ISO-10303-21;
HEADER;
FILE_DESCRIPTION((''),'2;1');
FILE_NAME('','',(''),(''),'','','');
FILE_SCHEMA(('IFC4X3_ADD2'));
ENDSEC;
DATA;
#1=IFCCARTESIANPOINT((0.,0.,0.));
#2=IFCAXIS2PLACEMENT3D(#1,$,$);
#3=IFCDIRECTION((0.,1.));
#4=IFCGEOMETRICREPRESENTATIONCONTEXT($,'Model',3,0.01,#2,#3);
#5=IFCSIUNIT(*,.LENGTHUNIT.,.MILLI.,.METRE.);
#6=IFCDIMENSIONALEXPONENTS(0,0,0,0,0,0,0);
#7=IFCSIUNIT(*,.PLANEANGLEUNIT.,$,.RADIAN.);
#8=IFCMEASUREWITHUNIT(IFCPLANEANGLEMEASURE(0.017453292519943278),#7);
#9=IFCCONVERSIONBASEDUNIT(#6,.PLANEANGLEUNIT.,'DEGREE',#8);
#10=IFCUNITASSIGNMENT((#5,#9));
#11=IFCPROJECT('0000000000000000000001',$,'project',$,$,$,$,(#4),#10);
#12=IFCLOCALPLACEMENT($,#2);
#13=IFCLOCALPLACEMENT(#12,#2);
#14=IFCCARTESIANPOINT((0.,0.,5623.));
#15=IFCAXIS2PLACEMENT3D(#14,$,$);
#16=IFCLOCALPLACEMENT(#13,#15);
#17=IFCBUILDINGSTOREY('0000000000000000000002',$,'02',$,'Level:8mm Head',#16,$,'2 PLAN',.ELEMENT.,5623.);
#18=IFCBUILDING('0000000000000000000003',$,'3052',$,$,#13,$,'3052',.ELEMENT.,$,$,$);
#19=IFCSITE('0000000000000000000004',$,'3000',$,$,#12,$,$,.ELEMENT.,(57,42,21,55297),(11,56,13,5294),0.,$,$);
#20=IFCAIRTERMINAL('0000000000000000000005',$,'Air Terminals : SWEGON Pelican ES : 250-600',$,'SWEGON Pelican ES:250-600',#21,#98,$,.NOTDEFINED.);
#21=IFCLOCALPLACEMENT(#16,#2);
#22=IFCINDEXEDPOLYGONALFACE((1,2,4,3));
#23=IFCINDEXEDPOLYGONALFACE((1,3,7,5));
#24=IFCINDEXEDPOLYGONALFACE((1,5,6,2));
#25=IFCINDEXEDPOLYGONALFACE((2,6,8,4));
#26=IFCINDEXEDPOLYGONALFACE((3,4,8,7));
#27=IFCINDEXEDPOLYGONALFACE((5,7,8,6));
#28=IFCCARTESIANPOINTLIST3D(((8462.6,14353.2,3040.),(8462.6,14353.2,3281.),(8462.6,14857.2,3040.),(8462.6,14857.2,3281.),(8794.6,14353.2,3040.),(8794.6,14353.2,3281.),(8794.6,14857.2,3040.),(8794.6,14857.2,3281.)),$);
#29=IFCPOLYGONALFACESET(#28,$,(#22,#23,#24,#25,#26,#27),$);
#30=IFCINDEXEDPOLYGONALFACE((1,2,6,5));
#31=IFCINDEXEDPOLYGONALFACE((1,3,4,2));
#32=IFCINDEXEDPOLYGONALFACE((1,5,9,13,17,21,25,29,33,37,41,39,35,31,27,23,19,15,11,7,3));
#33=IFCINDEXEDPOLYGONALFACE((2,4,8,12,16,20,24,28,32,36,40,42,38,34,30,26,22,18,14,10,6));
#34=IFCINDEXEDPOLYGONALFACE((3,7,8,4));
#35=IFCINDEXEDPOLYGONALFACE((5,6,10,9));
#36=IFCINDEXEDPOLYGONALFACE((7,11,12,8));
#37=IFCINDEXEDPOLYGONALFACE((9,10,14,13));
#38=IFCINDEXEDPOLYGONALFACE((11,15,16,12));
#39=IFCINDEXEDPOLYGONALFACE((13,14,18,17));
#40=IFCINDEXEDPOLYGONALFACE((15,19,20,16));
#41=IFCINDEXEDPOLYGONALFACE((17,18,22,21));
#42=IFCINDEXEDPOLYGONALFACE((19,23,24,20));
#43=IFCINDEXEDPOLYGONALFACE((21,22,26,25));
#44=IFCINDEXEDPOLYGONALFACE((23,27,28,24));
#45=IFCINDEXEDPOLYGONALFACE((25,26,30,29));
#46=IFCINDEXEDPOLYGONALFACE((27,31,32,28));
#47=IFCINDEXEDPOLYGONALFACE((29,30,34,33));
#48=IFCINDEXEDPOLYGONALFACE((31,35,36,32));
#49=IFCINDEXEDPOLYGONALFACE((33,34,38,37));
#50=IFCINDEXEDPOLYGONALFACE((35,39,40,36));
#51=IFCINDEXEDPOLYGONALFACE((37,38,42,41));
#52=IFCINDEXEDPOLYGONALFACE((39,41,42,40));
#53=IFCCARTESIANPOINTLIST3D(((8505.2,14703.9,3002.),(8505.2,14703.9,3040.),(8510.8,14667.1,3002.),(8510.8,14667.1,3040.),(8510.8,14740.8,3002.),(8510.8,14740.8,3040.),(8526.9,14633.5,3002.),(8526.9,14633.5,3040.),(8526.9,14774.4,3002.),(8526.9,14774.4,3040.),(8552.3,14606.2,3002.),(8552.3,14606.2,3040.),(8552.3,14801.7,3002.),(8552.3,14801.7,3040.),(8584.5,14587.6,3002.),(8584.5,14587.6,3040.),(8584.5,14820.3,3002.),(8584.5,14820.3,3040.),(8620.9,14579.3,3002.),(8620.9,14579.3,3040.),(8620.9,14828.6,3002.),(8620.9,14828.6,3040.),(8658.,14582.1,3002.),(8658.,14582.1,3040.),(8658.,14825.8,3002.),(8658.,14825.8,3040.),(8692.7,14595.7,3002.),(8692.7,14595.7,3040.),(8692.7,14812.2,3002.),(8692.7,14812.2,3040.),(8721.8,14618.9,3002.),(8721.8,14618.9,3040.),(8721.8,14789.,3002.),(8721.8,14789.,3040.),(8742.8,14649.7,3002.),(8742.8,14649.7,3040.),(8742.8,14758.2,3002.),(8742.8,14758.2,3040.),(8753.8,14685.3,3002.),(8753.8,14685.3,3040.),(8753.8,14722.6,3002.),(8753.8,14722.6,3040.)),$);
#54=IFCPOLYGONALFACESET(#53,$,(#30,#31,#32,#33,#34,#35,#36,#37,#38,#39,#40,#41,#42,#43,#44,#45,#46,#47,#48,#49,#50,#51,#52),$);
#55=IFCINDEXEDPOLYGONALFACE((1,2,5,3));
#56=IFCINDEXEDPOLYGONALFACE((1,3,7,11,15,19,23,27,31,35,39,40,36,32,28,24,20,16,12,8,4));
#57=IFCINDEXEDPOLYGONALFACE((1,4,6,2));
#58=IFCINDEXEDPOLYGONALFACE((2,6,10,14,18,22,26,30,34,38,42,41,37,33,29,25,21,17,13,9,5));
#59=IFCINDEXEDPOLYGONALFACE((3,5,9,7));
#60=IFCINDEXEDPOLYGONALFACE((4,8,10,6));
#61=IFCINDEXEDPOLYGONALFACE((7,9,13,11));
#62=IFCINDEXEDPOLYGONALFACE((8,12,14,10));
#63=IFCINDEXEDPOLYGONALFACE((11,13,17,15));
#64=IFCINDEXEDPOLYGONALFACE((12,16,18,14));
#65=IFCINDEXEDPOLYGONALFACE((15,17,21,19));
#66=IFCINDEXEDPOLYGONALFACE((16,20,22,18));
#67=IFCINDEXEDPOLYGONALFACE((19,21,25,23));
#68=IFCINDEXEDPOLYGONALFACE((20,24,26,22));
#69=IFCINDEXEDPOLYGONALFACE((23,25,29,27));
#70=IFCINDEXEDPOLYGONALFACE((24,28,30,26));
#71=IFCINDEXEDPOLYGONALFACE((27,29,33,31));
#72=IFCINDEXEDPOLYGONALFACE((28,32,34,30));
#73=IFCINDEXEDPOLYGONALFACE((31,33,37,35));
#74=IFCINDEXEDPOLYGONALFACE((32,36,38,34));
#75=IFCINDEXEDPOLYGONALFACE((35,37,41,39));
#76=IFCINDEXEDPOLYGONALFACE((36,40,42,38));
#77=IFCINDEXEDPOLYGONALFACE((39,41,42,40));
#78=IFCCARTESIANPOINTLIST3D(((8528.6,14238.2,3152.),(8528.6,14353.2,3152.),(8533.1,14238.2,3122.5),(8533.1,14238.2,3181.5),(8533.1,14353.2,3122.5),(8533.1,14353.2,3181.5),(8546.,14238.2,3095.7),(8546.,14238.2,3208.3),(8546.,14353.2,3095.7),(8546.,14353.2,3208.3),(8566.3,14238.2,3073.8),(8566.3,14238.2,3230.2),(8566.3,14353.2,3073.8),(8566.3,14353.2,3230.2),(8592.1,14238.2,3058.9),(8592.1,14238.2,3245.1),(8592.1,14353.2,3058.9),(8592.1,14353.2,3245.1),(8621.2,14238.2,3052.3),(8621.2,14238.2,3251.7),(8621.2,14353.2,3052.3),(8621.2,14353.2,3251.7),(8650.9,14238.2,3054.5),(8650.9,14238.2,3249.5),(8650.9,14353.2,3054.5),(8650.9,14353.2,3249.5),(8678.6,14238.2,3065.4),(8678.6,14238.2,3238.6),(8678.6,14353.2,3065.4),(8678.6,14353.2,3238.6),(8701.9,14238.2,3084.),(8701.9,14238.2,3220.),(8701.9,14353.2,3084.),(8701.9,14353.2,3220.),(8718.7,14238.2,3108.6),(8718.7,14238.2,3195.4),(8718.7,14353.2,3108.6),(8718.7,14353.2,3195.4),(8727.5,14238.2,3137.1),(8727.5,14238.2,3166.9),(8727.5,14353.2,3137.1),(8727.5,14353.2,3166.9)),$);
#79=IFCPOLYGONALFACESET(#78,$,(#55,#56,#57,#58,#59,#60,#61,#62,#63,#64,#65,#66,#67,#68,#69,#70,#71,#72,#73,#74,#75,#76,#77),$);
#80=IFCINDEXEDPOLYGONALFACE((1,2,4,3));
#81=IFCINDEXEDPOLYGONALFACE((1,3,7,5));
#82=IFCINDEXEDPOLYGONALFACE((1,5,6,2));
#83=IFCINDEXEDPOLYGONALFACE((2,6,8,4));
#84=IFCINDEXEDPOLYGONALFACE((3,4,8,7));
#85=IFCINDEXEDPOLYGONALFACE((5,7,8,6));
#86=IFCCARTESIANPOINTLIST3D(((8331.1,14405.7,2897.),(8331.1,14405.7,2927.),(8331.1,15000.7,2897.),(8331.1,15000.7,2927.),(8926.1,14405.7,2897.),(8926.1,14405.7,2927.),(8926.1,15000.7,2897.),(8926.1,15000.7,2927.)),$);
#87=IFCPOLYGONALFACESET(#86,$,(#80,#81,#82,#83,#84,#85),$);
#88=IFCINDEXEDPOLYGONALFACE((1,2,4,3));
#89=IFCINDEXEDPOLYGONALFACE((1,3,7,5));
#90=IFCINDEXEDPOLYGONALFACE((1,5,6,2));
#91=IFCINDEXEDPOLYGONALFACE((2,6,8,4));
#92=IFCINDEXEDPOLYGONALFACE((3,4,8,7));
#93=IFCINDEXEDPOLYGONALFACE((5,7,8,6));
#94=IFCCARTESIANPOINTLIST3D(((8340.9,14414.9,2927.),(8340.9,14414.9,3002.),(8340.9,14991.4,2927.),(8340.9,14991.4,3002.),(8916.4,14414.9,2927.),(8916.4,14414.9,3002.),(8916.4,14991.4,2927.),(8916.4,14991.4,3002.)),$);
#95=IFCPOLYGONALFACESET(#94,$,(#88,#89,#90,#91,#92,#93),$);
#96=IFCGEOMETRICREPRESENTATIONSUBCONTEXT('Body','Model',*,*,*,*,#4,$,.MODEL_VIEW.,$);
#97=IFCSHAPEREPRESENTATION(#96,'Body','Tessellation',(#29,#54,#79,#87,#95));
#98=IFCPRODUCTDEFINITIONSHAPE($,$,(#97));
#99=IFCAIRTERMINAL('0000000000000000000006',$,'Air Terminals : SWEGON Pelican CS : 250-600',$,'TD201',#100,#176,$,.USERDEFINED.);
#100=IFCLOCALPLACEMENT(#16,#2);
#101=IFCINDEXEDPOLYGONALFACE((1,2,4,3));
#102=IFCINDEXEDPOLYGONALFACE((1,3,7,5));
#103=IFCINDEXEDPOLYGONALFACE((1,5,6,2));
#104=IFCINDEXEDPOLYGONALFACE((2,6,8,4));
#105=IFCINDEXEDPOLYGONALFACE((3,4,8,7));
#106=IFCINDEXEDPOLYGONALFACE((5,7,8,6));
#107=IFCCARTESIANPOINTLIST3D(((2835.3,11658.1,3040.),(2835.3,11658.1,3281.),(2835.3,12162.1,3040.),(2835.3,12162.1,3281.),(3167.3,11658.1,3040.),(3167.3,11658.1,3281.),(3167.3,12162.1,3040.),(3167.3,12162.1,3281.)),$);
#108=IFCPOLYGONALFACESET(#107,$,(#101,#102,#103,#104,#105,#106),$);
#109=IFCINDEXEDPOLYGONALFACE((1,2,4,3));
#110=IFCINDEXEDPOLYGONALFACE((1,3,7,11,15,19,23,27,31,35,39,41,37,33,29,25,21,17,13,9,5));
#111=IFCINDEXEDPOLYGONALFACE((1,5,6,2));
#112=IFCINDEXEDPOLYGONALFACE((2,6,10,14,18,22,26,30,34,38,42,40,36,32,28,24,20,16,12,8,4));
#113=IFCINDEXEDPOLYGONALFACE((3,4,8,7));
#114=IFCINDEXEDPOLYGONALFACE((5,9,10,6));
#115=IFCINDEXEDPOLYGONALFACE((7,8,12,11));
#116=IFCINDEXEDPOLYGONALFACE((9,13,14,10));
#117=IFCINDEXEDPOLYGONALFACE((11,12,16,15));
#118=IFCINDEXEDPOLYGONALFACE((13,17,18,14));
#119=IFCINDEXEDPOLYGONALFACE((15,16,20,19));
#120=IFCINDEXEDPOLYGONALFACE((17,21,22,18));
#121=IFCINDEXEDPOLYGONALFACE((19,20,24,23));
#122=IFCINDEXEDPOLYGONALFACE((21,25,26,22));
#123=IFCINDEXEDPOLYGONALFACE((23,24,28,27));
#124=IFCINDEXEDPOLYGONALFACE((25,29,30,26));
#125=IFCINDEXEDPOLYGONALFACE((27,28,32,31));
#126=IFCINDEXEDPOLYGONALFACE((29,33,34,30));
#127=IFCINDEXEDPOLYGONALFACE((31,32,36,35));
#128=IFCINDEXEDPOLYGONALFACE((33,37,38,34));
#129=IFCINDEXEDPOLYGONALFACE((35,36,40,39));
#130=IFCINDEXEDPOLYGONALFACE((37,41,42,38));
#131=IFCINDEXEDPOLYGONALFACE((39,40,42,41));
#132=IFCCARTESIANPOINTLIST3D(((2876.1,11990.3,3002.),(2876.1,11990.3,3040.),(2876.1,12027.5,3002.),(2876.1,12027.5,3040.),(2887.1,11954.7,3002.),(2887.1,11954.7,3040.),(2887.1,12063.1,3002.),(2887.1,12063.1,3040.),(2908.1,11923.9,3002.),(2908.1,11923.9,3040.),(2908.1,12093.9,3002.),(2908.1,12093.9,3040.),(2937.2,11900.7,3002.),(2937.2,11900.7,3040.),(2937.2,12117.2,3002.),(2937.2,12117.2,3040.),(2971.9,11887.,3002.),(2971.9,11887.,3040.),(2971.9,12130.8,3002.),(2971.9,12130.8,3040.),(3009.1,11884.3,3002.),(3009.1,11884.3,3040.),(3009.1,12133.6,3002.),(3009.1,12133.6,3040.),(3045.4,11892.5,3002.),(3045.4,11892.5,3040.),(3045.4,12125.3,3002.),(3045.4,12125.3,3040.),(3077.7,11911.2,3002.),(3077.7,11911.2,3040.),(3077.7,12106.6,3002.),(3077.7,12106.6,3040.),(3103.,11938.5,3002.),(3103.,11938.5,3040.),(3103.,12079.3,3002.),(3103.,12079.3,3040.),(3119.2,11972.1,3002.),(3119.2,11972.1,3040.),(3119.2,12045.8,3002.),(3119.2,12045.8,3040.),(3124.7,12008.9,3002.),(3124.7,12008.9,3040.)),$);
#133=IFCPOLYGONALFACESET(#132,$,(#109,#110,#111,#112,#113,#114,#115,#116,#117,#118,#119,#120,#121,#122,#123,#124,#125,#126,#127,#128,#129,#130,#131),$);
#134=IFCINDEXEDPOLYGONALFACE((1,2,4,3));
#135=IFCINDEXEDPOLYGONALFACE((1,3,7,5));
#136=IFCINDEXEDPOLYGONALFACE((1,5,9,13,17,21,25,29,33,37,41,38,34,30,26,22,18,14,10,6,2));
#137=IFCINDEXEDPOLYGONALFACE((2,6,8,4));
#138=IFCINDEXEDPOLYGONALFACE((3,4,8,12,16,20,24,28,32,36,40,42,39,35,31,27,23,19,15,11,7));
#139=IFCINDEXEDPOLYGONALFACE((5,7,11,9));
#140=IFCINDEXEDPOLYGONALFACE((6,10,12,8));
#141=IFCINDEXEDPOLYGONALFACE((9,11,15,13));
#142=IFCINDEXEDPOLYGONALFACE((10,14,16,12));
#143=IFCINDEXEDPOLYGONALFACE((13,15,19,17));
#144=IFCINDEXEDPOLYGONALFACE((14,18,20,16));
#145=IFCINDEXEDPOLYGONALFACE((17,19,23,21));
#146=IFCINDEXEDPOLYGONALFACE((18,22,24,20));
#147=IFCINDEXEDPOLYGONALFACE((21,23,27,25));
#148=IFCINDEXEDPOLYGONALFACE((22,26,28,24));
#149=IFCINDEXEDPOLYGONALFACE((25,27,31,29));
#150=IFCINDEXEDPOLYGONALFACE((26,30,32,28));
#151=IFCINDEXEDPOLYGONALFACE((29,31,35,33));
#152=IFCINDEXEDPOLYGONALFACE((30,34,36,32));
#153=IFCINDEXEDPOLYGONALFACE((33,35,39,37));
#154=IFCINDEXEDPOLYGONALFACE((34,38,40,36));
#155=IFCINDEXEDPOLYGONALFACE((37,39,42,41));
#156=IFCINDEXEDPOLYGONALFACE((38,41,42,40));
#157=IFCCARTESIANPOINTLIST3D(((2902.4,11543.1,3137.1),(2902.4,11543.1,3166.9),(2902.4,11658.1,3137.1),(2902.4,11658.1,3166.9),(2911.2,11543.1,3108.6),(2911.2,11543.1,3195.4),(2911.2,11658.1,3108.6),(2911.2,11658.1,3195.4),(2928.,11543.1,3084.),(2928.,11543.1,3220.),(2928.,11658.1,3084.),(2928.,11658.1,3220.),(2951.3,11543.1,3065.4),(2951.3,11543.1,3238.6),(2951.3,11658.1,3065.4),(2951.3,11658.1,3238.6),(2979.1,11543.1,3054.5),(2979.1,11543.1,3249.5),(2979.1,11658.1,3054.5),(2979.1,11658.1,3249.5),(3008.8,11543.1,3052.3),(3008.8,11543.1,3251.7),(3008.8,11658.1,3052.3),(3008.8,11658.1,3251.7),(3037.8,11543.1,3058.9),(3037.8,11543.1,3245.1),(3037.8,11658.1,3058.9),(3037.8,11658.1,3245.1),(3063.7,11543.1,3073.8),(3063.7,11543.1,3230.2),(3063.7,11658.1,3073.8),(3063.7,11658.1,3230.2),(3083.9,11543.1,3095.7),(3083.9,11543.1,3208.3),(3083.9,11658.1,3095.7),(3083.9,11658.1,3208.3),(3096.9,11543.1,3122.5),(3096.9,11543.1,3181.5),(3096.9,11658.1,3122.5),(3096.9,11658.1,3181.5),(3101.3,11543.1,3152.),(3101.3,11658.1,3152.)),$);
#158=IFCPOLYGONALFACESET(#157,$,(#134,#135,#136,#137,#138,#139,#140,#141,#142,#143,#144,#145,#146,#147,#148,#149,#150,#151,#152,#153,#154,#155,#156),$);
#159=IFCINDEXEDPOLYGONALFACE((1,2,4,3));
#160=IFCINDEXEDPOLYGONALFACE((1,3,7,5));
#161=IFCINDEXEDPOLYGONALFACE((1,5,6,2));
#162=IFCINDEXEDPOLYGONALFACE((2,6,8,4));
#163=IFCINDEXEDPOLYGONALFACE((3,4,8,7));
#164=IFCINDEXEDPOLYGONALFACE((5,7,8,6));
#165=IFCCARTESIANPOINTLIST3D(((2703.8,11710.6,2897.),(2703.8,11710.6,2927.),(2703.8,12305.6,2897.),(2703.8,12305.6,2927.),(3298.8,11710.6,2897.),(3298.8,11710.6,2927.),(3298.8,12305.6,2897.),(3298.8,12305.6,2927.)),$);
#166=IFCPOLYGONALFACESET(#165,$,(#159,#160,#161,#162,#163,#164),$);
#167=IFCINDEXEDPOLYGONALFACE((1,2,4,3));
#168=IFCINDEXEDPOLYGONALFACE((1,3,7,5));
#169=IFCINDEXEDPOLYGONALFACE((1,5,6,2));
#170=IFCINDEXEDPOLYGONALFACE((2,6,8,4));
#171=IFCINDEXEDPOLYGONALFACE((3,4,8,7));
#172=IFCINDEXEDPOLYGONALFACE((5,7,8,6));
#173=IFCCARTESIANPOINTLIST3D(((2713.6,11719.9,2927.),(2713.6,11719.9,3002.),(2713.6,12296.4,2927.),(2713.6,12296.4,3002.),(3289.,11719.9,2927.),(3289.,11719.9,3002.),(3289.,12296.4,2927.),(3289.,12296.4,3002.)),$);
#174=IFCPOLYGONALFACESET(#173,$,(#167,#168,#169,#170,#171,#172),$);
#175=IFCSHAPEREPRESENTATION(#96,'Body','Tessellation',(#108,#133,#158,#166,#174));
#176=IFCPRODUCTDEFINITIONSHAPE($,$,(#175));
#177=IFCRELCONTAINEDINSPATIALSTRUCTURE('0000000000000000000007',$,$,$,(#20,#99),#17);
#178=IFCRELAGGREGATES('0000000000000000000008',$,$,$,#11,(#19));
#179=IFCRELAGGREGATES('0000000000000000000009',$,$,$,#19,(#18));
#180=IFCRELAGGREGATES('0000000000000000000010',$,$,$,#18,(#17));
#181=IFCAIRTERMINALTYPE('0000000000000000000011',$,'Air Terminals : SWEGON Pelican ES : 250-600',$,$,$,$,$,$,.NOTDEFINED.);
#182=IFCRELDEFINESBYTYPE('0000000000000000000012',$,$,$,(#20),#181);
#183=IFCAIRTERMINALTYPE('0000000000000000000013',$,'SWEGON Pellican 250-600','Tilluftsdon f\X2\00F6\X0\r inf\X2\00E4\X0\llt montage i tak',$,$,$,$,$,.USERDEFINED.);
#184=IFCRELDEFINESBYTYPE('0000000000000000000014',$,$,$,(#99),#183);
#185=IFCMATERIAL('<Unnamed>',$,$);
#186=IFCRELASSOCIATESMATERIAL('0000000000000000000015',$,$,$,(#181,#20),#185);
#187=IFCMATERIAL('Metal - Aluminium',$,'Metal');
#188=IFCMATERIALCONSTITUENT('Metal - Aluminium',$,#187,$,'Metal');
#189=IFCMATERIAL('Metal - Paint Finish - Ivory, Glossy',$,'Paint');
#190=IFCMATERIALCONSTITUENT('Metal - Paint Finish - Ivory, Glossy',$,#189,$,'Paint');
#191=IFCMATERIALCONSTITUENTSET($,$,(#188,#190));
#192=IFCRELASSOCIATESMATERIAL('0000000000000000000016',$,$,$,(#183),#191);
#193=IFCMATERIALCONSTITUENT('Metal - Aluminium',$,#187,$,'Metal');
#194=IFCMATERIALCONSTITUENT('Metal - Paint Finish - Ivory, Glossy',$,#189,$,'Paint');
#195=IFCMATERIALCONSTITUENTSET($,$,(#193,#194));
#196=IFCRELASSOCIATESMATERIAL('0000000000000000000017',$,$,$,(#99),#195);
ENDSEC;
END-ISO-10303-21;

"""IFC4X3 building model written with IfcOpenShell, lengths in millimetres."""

from ifc_helpers import new_model, entity, si_unit, converted_unit, direction, frame, frame_2d, origin, origin_2d_with_axis, place, context, subcontext, project, spatial, rectangle, circle, extrude, source, transform, mapped, material, constituent, constituent_set, type_object, type_shapes, element, save


model = new_model("IFC4X3")

# Units and contexts
model_context = context("Model", 3, precision=0.01, world=origin(), true_north=direction((0.0, 1.0)))
body_context = subcontext(model_context, "Body", "Model", "MODEL_VIEW")
ifc_project = project(units=[si_unit("LENGTHUNIT", "METRE", prefix="MILLI"), converted_unit("PLANEANGLEUNIT", "DEGREE", entity("IfcPlaneAngleMeasure", 0.017453292519943278), si_unit("PLANEANGLEUNIT", "RADIAN"), dimensions=[0, 0, 0, 0, 0, 0, 0])], contexts=[model_context])

# Site, building, storey
site_placement = place(None, origin())
site = spatial("IfcSite", under=ifc_project, at=site_placement, Name="3000", CompositionType="ELEMENT", RefLatitude=(57, 42, 21, 55297), RefLongitude=(11, 56, 13, 5294), RefElevation=0.0)
building_placement = place(site_placement, origin())
building = spatial("IfcBuilding", under=site, at=building_placement, Name="3052", LongName="3052", CompositionType="ELEMENT")
storey_placement = place(building_placement, frame((0.0, 0.0, 5623.0)))
storey = spatial("IfcBuildingStorey", under=building, at=storey_placement, Name="02", ObjectType="Level:8mm Head", LongName="2 PLAN", CompositionType="ELEMENT", Elevation=5623.0)

# Air terminals
ifc_material_1 = material(Name="<Unnamed>")
air_terminal_type_1 = type_object("IfcAirTerminalType", Name="Air Terminals : SWEGON Pelican ES : 250-600", PredefinedType="NOTDEFINED", material=ifc_material_1)
shared_shape_1 = source(origin(), body_context, "Body", "SweptSolid", [
    extrude(rectangle(XDim=504.0, YDim=332.0, at=origin_2d_with_axis()), frame((0.0, -98.0, -354.0), z_axis=(0.0, 0.0, 1.0), x_axis=(0.0, 1.0, 0.0)), (0.0, 0.0, 1.0), 241.0),
    extrude(circle(Radius=125.0, at=frame_2d((0.0, 0.0), x_axis=(1.0, 0.0))), frame((-1.6, 0.8, -113.0)), (0.0, 0.0, 1.0), 38.0),
    extrude(circle(Radius=100.0, at=frame_2d((0.0, 0.0), x_axis=(1.0, 0.0))), frame((0.0, -465.0, -225.0), z_axis=(0.0, 1.0, 0.0), x_axis=(1.0, 0.0, 0.0)), (0.0, 0.0, 1.0), 115.0),
    extrude(rectangle(XDim=595.0, YDim=595.0, at=frame_2d((0.0, 0.0), x_axis=(1.0, 0.0))), frame((0.0, 0.0, 0.0), z_axis=(0.0, 0.0, 1.0), x_axis=(0.0, 1.0, 0.0)), (0.0, 0.0, 1.0), 30.0),
    extrude(rectangle(XDim=576.5, YDim=575.5, at=origin_2d_with_axis()), frame((0.0, 0.0, -75.0), z_axis=(0.0, 0.0, 1.0), x_axis=(0.0, 1.0, 0.0)), (0.0, 0.0, 1.0), 75.0),
])
type_shapes(air_terminal_type_1, [shared_shape_1])
for number, where, z_axis, x_axis, name in (
    (1, (8628.6, 14703.2, 2927.0), (0.0, 0.0, -1.0), (-1.0, 0.0, 0.0), "Air Terminals : SWEGON Pelican ES : 250-600"),
):
    element("IfcAirTerminal", number, at=place(storey_placement, frame(where, z_axis=z_axis, x_axis=x_axis)), inside=storey, type_object=air_terminal_type_1, material=ifc_material_1, Name=name, ObjectType="SWEGON Pelican ES:250-600", PredefinedType="NOTDEFINED", context=body_context, shape_type="MappedRepresentation", body=[
        mapped(shared_shape_1, transform((0.0, 0.0, 0.0), scale=1.0)),
    ])
ifc_material_2 = material(Name="Metal - Aluminium", Category="Metal")
ifc_constituent_1 = constituent(ifc_material_2, Name="Metal - Aluminium", Category="Metal")
ifc_material_3 = material(Name="Metal - Paint Finish - Ivory, Glossy", Category="Paint")
ifc_constituent_2 = constituent(ifc_material_3, Name="Metal - Paint Finish - Ivory, Glossy", Category="Paint")
ifc_constituent_set_1 = constituent_set(constituents=[ifc_constituent_1, ifc_constituent_2])
ifc_constituent_3 = constituent(ifc_material_2, Name="Metal - Aluminium", Category="Metal")
ifc_constituent_4 = constituent(ifc_material_3, Name="Metal - Paint Finish - Ivory, Glossy", Category="Paint")
ifc_constituent_set_2 = constituent_set(constituents=[ifc_constituent_3, ifc_constituent_4])
air_terminal_type_2 = type_object("IfcAirTerminalType", Name="SWEGON Pellican 250-600", Description="Tilluftsdon för infällt montage i tak", PredefinedType="USERDEFINED", material=ifc_constituent_set_2)
shared_shape_2 = source(origin(), body_context, "Body", "SweptSolid", [
    extrude(rectangle(XDim=332.0, YDim=504.0, at=origin_2d_with_axis()), frame((0.0, 98.0, -354.0), z_axis=(0.0, 0.0, 1.0), x_axis=(-1.0, 0.0, 0.0)), (0.0, 0.0, 1.0), 241.0),
    extrude(circle(Radius=125.0, at=frame_2d((0.0, 0.0), x_axis=(1.0, 0.0))), frame((-1.6, -0.8, -113.0)), (0.0, 0.0, 1.0), 38.0),
    extrude(circle(Radius=100.0, at=frame_2d((0.0, 0.0), x_axis=(1.0, 0.0))), frame((0.0, 350.0, -225.0), z_axis=(0.0, 1.0, 0.0), x_axis=(1.0, 0.0, 0.0)), (0.0, 0.0, 1.0), 115.0),
    extrude(rectangle(XDim=595.0, YDim=595.0, at=frame_2d((0.0, 0.0), x_axis=(1.0, 0.0))), frame((0.0, 0.0, 0.0), z_axis=(0.0, 0.0, 1.0), x_axis=(-1.0, 0.0, 0.0)), (0.0, 0.0, 1.0), 30.0),
    extrude(rectangle(XDim=575.5, YDim=576.5, at=origin_2d_with_axis()), frame((0.0, 0.0, -75.0), z_axis=(0.0, 0.0, 1.0), x_axis=(-1.0, 0.0, 0.0)), (0.0, 0.0, 1.0), 75.0),
])
type_shapes(air_terminal_type_2, [shared_shape_2])
air_terminal_1_placement = place(storey_placement, frame((3001.3, 12008.1, 2927.0), z_axis=(0.0, 0.0, -1.0), x_axis=(1.0, 0.0, 0.0)))
element("IfcAirTerminal", 2, at=air_terminal_1_placement, inside=storey, type_object=air_terminal_type_2, material=ifc_constituent_set_1, Name="Air Terminals : SWEGON Pelican CS : 250-600", ObjectType="TD201", PredefinedType="USERDEFINED", context=body_context, shape_type="MappedRepresentation", body=[
    mapped(shared_shape_2, transform((0.0, 0.0, 0.0), scale=1.0)),
])

save(model, "model.ifc")
